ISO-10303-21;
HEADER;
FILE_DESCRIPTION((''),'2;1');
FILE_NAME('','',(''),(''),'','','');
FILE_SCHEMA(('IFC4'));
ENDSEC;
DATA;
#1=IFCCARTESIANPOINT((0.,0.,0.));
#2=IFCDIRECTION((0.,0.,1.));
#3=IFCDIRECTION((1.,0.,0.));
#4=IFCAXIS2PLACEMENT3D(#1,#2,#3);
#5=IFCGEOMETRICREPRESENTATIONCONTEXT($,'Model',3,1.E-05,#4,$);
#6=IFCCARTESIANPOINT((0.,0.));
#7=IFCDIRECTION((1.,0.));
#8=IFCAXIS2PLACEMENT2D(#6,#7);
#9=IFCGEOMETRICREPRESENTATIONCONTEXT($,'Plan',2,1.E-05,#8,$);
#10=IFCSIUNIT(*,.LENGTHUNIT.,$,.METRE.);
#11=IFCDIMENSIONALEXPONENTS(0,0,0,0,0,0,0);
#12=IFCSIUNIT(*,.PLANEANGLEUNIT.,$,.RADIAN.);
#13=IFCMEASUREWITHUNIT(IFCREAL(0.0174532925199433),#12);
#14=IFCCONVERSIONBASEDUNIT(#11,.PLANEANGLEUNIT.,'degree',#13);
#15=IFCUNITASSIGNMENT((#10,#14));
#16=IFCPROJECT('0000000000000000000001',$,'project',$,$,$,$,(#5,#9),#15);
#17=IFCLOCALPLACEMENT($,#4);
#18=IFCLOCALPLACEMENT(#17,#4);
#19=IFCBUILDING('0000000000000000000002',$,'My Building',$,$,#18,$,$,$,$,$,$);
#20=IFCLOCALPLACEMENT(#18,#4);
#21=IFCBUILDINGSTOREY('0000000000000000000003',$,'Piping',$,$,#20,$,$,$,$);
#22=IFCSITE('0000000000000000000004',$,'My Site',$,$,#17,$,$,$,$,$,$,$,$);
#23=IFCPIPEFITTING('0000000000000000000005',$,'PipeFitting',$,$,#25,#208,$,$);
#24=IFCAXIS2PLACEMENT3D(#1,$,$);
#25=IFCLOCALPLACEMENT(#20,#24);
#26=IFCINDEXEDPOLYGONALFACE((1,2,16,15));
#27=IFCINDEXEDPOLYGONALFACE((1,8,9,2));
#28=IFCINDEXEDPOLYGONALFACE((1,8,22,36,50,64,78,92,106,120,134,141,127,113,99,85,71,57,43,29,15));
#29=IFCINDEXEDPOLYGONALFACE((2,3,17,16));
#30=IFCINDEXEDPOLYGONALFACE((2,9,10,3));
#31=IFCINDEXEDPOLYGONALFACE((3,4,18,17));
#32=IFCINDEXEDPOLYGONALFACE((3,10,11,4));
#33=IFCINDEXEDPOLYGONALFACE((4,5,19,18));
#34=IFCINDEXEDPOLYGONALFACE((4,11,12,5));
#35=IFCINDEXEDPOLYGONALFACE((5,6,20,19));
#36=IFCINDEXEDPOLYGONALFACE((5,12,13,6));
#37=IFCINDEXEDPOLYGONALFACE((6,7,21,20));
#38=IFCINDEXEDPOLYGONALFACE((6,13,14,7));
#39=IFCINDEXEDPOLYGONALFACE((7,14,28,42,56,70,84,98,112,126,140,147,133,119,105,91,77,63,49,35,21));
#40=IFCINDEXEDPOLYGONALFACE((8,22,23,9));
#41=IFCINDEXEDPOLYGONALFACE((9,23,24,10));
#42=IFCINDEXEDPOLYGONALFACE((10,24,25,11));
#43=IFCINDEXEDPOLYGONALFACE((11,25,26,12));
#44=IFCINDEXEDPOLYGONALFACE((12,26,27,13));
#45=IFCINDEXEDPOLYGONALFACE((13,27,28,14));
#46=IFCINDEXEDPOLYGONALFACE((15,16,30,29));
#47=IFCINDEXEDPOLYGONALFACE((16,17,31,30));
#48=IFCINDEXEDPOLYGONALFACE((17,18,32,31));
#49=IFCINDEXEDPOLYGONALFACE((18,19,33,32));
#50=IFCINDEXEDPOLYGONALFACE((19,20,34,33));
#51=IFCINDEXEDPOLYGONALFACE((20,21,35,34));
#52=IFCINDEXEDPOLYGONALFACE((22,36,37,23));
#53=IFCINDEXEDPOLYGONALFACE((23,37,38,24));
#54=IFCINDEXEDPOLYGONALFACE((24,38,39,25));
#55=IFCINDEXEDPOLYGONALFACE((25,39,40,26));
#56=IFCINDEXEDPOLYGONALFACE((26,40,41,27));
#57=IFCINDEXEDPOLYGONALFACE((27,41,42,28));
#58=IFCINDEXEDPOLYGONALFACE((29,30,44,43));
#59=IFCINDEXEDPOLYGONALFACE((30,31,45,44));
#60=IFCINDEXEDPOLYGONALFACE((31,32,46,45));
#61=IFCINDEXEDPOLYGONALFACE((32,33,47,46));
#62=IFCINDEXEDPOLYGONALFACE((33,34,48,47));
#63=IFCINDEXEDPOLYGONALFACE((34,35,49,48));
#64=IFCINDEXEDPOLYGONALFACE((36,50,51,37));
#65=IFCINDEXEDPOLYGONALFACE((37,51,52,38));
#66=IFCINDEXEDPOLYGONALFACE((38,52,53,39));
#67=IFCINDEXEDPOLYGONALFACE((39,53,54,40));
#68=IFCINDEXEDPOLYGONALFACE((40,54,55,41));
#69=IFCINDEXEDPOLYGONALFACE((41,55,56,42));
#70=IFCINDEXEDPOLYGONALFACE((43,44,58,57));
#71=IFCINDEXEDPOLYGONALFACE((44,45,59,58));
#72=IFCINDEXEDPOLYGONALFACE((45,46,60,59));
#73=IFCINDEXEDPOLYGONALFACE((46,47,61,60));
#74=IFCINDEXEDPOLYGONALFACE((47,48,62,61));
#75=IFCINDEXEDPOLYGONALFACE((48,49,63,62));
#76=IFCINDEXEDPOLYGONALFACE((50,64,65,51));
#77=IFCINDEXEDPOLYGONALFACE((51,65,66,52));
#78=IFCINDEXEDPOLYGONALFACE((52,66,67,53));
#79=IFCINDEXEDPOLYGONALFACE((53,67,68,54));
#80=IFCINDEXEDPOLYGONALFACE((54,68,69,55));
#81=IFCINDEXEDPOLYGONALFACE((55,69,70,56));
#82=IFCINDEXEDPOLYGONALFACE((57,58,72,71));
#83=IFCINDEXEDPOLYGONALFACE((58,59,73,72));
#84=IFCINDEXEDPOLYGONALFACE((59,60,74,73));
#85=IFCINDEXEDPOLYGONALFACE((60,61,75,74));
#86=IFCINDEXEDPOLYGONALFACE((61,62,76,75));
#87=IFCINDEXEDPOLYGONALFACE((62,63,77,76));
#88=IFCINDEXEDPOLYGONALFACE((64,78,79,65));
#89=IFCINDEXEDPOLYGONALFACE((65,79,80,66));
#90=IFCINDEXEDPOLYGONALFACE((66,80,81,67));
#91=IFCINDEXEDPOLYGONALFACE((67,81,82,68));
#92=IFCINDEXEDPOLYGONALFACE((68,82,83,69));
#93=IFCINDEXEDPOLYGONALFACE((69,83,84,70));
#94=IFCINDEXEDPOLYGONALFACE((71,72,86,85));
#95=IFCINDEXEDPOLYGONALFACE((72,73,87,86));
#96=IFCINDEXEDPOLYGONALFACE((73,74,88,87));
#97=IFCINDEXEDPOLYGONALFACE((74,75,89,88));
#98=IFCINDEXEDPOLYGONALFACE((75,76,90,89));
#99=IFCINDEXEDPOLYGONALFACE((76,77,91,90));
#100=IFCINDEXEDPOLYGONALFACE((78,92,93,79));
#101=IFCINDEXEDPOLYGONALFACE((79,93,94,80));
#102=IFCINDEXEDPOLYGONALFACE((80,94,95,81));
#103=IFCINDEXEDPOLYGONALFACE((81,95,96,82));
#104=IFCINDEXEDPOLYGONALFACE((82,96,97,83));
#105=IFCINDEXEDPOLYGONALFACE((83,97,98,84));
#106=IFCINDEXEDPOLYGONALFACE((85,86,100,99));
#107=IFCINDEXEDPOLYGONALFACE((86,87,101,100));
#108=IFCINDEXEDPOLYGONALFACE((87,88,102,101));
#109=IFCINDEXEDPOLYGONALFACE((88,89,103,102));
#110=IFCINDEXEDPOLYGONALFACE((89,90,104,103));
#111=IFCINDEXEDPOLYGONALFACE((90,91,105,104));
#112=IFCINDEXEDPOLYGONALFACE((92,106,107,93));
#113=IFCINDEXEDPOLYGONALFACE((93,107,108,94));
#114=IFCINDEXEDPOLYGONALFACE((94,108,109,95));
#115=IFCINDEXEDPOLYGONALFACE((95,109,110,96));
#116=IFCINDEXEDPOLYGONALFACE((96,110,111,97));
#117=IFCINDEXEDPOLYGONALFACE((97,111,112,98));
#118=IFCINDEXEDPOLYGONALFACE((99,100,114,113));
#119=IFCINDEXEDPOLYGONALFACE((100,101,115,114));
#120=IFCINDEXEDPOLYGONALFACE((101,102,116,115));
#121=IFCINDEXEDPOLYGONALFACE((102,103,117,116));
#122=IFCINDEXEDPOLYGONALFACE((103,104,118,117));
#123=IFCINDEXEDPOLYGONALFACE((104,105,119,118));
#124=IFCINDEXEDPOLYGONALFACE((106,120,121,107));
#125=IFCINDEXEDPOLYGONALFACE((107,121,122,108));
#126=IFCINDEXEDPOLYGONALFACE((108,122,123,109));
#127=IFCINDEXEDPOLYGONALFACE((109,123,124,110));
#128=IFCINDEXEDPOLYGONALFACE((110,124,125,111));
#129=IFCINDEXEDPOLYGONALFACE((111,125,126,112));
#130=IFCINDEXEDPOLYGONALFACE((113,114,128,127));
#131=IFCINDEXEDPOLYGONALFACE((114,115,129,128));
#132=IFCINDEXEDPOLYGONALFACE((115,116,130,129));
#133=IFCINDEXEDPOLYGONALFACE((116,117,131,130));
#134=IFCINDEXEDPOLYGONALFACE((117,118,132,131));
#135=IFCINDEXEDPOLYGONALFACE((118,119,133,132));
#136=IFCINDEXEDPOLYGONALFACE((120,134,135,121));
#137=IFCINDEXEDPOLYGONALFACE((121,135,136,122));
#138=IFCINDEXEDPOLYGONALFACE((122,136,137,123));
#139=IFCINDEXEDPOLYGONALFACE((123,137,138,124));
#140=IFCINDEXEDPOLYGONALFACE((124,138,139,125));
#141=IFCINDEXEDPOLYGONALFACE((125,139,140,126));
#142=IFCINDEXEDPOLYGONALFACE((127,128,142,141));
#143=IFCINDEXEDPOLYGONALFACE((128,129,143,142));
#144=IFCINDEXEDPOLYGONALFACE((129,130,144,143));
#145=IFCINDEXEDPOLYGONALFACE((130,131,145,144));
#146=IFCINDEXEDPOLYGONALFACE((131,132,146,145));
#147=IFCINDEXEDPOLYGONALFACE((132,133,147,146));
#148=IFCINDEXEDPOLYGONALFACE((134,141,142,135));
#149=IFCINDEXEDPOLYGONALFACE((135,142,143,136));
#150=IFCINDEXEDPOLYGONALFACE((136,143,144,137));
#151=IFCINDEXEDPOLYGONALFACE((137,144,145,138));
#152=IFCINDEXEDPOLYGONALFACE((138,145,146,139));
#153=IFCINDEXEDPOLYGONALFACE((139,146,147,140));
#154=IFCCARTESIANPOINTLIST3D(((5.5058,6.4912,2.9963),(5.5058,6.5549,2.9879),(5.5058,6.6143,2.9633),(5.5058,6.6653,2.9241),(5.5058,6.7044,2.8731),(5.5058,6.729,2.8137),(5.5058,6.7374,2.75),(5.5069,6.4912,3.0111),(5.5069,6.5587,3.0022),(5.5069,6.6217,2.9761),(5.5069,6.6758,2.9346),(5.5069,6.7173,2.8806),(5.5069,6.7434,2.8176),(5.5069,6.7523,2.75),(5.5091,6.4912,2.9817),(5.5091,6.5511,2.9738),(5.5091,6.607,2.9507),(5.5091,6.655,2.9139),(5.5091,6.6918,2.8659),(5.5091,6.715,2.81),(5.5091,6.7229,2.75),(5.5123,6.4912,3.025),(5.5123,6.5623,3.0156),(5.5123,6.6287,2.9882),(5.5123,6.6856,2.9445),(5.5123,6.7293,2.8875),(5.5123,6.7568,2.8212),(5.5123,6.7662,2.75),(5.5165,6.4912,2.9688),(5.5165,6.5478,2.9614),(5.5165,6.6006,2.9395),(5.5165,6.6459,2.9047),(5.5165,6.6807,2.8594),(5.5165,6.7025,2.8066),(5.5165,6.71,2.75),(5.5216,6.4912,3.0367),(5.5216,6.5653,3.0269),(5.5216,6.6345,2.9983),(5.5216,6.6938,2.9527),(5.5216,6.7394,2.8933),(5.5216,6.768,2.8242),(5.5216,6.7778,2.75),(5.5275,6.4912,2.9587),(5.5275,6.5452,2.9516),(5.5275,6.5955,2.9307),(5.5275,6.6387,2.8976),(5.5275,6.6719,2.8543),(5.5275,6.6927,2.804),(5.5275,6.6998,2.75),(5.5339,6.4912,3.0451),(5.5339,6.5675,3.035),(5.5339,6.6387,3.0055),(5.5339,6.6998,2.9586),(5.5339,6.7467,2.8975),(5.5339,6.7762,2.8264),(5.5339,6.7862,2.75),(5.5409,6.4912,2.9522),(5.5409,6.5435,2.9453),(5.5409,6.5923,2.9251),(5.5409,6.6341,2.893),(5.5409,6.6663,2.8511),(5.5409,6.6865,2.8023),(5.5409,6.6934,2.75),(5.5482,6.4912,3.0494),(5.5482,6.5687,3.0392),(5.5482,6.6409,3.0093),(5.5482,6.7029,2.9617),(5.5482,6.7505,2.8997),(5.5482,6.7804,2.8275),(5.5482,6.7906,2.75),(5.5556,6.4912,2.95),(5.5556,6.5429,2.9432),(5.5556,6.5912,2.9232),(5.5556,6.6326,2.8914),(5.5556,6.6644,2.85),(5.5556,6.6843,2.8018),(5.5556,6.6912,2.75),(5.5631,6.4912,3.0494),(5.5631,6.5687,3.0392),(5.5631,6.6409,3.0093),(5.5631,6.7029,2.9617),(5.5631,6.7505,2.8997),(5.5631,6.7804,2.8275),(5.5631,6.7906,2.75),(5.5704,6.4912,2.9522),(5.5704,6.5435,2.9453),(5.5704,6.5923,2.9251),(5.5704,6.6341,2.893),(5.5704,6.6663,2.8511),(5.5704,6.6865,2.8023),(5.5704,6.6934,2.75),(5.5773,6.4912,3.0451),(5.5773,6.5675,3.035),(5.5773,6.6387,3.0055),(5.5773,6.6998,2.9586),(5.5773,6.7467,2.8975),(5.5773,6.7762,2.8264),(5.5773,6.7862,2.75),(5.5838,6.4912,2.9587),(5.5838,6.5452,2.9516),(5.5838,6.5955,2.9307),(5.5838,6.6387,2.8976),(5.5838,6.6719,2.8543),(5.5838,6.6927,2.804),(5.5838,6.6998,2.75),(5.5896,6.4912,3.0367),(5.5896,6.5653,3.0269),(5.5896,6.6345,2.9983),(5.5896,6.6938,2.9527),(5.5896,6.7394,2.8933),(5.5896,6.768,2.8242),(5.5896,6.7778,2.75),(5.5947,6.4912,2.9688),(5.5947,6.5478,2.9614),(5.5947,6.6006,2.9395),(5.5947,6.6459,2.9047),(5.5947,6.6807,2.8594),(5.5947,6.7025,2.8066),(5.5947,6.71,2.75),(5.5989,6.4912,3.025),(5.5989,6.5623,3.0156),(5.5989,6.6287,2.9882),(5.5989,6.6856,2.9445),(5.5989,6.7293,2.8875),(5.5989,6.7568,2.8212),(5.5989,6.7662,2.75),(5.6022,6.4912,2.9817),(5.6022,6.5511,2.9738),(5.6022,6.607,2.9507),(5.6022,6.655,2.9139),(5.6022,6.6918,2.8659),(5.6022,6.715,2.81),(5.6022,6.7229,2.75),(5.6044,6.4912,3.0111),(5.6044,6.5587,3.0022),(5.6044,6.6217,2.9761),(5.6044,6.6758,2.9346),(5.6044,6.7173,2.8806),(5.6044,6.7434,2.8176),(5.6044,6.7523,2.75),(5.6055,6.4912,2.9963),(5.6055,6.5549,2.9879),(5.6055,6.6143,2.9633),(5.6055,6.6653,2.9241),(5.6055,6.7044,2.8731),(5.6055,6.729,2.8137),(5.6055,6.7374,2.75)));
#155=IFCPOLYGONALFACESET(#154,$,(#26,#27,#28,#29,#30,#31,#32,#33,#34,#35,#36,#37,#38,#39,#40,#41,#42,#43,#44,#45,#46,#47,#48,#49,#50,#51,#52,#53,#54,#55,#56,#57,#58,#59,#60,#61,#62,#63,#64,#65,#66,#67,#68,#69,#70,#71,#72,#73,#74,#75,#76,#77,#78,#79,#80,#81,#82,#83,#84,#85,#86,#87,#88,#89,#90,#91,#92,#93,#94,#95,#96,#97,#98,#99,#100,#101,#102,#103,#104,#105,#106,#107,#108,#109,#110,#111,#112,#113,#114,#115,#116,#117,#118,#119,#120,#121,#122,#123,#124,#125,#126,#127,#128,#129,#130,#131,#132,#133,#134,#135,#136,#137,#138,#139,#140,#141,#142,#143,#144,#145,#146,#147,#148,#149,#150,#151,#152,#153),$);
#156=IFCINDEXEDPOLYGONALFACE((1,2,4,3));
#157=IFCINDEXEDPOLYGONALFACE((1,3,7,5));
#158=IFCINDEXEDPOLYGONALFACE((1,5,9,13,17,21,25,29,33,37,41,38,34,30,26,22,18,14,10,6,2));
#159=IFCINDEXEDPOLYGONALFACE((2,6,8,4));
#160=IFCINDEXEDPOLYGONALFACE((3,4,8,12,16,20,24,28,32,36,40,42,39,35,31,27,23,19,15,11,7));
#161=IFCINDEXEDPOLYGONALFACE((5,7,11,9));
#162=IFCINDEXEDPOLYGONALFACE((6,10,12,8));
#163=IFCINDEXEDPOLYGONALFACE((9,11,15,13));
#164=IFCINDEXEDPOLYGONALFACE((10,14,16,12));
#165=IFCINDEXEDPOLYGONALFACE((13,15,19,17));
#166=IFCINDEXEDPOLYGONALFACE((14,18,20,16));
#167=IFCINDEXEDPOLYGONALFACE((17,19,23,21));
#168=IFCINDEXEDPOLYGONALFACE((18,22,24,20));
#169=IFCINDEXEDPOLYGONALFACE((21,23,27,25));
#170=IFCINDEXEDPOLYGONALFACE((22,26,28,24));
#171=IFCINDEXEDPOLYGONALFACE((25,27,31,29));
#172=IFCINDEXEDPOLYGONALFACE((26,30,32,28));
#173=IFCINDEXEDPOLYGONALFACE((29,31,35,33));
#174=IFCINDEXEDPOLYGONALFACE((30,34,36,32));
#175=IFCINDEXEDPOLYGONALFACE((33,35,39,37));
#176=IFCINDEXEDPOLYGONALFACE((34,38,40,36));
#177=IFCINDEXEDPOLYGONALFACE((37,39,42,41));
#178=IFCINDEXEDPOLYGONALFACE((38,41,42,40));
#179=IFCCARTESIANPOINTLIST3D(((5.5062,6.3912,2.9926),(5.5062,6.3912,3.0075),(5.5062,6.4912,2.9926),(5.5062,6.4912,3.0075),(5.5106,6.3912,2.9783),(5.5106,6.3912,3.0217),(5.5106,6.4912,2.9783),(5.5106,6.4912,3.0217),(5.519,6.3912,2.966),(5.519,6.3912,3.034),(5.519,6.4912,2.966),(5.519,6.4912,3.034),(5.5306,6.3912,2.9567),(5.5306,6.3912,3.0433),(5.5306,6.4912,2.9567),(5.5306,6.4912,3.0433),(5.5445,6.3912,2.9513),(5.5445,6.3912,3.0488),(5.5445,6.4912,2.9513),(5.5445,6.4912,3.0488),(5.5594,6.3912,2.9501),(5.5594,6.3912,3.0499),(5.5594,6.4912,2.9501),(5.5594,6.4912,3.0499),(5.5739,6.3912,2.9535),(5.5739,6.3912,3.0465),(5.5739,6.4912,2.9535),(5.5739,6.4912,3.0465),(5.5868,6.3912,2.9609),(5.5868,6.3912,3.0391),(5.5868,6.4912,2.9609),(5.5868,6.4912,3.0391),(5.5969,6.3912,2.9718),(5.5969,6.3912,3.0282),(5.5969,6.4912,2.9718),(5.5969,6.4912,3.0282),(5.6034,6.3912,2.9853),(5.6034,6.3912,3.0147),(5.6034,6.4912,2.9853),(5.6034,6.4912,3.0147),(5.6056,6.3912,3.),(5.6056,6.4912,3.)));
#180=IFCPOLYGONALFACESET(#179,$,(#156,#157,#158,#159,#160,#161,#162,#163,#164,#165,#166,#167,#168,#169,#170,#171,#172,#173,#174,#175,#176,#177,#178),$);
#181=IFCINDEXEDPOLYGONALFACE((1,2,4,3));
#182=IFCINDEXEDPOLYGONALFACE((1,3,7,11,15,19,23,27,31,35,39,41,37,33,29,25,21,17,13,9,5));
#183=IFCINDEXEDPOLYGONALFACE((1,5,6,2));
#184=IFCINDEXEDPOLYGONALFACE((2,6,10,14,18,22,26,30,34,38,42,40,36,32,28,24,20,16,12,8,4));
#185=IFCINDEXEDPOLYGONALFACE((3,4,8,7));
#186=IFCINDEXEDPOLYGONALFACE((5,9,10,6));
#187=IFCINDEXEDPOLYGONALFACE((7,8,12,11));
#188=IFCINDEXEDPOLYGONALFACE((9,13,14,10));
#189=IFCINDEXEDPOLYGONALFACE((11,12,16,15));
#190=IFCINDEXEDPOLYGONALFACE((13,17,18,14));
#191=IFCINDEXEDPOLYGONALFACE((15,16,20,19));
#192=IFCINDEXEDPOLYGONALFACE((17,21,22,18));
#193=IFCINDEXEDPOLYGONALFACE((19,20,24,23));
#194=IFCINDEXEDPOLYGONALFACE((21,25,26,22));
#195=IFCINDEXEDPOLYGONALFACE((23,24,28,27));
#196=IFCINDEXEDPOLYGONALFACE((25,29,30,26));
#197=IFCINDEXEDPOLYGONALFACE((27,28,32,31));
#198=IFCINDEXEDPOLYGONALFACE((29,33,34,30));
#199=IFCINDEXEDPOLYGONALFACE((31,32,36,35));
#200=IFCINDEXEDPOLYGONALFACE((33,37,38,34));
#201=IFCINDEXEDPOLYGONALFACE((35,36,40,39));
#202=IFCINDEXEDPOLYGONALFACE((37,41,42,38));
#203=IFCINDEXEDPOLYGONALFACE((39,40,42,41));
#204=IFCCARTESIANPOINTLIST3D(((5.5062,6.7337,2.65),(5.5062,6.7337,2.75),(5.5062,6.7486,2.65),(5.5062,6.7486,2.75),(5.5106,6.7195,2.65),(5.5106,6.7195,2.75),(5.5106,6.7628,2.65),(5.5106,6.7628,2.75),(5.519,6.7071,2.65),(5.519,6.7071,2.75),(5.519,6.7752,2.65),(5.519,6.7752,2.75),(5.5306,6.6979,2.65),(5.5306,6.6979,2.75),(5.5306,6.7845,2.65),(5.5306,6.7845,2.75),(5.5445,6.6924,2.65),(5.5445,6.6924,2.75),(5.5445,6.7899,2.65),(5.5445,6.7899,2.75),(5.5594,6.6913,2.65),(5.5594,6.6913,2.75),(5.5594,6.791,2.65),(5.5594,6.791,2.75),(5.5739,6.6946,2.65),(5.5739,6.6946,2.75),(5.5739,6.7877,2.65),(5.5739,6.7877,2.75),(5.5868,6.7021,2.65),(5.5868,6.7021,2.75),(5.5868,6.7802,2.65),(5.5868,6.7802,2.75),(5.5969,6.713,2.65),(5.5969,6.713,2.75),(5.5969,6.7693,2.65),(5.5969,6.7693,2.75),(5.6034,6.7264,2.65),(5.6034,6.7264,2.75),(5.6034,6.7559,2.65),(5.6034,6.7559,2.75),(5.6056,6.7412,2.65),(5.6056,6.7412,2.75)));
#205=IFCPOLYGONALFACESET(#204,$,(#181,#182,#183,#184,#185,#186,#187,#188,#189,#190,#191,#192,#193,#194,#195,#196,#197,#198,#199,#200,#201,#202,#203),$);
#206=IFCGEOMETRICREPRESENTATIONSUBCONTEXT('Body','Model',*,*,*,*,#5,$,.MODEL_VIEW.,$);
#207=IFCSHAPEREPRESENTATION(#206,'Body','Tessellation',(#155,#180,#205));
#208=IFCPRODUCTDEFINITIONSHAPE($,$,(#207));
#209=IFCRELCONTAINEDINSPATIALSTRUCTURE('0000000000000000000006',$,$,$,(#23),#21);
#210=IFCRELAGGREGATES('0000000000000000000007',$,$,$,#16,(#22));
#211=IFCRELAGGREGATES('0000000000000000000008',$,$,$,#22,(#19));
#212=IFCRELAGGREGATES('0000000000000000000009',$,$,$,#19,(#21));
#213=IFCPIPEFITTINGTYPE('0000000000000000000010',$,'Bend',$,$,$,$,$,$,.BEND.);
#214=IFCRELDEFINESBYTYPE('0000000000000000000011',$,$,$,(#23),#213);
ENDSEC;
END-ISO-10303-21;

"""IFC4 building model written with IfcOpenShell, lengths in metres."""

from ifc_helpers import new_model, entity, si_unit, converted_unit, frame, origin_with_axes, origin_2d_with_axis, place, context, subcontext, project, spatial, circle, extrude, source, transform, mapped, type_object, type_shapes, element, save


model = new_model("IFC4")

# Units and contexts
model_context = context("Model", 3, precision=1e-05, world=origin_with_axes())
plan_context = context("Plan", 2, precision=1e-05, world=origin_2d_with_axis())
body_context = subcontext(model_context, "Body", "Model", "MODEL_VIEW")
ifc_project = project(units=[si_unit("LENGTHUNIT", "METRE"), converted_unit("PLANEANGLEUNIT", "degree", entity("IfcReal", 0.0174532925199433), si_unit("PLANEANGLEUNIT", "RADIAN"), dimensions=[0, 0, 0, 0, 0, 0, 0])], contexts=[model_context, plan_context])

# Site, building, storey
site_placement = place(None, origin_with_axes())
site = spatial("IfcSite", under=ifc_project, at=site_placement, Name="My Site")
building_placement = place(site_placement, origin_with_axes())
building = spatial("IfcBuilding", under=site, at=building_placement, Name="My Building")
storey_placement = place(building_placement, origin_with_axes())
storey = spatial("IfcBuildingStorey", under=building, at=storey_placement, Name="Piping")

# Pipe fitting
pipe_fitting_type = type_object("IfcPipeFittingType", Name="Bend", PredefinedType="BEND")
shared_shape = source(origin_with_axes(), body_context, "Body", "SolidModel", [
    entity("IfcSweptDiskSolid", entity("IfcIndexedPolyCurve", entity("IfcCartesianPointList3D", [[0.0, 0.0, -0.1], [0.0, -0.0732, -0.2768], [0.0, -0.25, -0.35]]), [entity("IfcArcIndex", [1, 2, 3])]), 0.05),
    extrude(circle(Radius=0.05), origin_with_axes(), (0.0, 0.0, -1.0), 0.1),
    extrude(circle(Radius=0.05), frame((0.0, -0.25, -0.35), z_axis=(0.0, -1.0, 0.0), x_axis=(1.0, 0.0, 0.0)), (0.0, 0.0, 1.0), 0.1),
])
type_shapes(pipe_fitting_type, [shared_shape])
for number, where, z_axis, x_axis, name in (
    (1, (5.5556, 6.3912, 3.0), (0.0, -1.0, 0.0), (1.0, 0.0, 0.0), "PipeFitting"),
):
    element("IfcPipeFitting", number, at=place(storey_placement, frame(where, z_axis=z_axis, x_axis=x_axis)), inside=storey, type_object=pipe_fitting_type, Name=name, context=body_context, shape_type="MappedRepresentation", body=[
        mapped(shared_shape, transform((0.0, 0.0, 0.0), x_axis=(1.0, 0.0, 0.0), y_axis=(0.0, 1.0, 0.0), z_axis=(0.0, 0.0, 1.0), scale=1.0)),
    ])

save(model, "model.ifc")
